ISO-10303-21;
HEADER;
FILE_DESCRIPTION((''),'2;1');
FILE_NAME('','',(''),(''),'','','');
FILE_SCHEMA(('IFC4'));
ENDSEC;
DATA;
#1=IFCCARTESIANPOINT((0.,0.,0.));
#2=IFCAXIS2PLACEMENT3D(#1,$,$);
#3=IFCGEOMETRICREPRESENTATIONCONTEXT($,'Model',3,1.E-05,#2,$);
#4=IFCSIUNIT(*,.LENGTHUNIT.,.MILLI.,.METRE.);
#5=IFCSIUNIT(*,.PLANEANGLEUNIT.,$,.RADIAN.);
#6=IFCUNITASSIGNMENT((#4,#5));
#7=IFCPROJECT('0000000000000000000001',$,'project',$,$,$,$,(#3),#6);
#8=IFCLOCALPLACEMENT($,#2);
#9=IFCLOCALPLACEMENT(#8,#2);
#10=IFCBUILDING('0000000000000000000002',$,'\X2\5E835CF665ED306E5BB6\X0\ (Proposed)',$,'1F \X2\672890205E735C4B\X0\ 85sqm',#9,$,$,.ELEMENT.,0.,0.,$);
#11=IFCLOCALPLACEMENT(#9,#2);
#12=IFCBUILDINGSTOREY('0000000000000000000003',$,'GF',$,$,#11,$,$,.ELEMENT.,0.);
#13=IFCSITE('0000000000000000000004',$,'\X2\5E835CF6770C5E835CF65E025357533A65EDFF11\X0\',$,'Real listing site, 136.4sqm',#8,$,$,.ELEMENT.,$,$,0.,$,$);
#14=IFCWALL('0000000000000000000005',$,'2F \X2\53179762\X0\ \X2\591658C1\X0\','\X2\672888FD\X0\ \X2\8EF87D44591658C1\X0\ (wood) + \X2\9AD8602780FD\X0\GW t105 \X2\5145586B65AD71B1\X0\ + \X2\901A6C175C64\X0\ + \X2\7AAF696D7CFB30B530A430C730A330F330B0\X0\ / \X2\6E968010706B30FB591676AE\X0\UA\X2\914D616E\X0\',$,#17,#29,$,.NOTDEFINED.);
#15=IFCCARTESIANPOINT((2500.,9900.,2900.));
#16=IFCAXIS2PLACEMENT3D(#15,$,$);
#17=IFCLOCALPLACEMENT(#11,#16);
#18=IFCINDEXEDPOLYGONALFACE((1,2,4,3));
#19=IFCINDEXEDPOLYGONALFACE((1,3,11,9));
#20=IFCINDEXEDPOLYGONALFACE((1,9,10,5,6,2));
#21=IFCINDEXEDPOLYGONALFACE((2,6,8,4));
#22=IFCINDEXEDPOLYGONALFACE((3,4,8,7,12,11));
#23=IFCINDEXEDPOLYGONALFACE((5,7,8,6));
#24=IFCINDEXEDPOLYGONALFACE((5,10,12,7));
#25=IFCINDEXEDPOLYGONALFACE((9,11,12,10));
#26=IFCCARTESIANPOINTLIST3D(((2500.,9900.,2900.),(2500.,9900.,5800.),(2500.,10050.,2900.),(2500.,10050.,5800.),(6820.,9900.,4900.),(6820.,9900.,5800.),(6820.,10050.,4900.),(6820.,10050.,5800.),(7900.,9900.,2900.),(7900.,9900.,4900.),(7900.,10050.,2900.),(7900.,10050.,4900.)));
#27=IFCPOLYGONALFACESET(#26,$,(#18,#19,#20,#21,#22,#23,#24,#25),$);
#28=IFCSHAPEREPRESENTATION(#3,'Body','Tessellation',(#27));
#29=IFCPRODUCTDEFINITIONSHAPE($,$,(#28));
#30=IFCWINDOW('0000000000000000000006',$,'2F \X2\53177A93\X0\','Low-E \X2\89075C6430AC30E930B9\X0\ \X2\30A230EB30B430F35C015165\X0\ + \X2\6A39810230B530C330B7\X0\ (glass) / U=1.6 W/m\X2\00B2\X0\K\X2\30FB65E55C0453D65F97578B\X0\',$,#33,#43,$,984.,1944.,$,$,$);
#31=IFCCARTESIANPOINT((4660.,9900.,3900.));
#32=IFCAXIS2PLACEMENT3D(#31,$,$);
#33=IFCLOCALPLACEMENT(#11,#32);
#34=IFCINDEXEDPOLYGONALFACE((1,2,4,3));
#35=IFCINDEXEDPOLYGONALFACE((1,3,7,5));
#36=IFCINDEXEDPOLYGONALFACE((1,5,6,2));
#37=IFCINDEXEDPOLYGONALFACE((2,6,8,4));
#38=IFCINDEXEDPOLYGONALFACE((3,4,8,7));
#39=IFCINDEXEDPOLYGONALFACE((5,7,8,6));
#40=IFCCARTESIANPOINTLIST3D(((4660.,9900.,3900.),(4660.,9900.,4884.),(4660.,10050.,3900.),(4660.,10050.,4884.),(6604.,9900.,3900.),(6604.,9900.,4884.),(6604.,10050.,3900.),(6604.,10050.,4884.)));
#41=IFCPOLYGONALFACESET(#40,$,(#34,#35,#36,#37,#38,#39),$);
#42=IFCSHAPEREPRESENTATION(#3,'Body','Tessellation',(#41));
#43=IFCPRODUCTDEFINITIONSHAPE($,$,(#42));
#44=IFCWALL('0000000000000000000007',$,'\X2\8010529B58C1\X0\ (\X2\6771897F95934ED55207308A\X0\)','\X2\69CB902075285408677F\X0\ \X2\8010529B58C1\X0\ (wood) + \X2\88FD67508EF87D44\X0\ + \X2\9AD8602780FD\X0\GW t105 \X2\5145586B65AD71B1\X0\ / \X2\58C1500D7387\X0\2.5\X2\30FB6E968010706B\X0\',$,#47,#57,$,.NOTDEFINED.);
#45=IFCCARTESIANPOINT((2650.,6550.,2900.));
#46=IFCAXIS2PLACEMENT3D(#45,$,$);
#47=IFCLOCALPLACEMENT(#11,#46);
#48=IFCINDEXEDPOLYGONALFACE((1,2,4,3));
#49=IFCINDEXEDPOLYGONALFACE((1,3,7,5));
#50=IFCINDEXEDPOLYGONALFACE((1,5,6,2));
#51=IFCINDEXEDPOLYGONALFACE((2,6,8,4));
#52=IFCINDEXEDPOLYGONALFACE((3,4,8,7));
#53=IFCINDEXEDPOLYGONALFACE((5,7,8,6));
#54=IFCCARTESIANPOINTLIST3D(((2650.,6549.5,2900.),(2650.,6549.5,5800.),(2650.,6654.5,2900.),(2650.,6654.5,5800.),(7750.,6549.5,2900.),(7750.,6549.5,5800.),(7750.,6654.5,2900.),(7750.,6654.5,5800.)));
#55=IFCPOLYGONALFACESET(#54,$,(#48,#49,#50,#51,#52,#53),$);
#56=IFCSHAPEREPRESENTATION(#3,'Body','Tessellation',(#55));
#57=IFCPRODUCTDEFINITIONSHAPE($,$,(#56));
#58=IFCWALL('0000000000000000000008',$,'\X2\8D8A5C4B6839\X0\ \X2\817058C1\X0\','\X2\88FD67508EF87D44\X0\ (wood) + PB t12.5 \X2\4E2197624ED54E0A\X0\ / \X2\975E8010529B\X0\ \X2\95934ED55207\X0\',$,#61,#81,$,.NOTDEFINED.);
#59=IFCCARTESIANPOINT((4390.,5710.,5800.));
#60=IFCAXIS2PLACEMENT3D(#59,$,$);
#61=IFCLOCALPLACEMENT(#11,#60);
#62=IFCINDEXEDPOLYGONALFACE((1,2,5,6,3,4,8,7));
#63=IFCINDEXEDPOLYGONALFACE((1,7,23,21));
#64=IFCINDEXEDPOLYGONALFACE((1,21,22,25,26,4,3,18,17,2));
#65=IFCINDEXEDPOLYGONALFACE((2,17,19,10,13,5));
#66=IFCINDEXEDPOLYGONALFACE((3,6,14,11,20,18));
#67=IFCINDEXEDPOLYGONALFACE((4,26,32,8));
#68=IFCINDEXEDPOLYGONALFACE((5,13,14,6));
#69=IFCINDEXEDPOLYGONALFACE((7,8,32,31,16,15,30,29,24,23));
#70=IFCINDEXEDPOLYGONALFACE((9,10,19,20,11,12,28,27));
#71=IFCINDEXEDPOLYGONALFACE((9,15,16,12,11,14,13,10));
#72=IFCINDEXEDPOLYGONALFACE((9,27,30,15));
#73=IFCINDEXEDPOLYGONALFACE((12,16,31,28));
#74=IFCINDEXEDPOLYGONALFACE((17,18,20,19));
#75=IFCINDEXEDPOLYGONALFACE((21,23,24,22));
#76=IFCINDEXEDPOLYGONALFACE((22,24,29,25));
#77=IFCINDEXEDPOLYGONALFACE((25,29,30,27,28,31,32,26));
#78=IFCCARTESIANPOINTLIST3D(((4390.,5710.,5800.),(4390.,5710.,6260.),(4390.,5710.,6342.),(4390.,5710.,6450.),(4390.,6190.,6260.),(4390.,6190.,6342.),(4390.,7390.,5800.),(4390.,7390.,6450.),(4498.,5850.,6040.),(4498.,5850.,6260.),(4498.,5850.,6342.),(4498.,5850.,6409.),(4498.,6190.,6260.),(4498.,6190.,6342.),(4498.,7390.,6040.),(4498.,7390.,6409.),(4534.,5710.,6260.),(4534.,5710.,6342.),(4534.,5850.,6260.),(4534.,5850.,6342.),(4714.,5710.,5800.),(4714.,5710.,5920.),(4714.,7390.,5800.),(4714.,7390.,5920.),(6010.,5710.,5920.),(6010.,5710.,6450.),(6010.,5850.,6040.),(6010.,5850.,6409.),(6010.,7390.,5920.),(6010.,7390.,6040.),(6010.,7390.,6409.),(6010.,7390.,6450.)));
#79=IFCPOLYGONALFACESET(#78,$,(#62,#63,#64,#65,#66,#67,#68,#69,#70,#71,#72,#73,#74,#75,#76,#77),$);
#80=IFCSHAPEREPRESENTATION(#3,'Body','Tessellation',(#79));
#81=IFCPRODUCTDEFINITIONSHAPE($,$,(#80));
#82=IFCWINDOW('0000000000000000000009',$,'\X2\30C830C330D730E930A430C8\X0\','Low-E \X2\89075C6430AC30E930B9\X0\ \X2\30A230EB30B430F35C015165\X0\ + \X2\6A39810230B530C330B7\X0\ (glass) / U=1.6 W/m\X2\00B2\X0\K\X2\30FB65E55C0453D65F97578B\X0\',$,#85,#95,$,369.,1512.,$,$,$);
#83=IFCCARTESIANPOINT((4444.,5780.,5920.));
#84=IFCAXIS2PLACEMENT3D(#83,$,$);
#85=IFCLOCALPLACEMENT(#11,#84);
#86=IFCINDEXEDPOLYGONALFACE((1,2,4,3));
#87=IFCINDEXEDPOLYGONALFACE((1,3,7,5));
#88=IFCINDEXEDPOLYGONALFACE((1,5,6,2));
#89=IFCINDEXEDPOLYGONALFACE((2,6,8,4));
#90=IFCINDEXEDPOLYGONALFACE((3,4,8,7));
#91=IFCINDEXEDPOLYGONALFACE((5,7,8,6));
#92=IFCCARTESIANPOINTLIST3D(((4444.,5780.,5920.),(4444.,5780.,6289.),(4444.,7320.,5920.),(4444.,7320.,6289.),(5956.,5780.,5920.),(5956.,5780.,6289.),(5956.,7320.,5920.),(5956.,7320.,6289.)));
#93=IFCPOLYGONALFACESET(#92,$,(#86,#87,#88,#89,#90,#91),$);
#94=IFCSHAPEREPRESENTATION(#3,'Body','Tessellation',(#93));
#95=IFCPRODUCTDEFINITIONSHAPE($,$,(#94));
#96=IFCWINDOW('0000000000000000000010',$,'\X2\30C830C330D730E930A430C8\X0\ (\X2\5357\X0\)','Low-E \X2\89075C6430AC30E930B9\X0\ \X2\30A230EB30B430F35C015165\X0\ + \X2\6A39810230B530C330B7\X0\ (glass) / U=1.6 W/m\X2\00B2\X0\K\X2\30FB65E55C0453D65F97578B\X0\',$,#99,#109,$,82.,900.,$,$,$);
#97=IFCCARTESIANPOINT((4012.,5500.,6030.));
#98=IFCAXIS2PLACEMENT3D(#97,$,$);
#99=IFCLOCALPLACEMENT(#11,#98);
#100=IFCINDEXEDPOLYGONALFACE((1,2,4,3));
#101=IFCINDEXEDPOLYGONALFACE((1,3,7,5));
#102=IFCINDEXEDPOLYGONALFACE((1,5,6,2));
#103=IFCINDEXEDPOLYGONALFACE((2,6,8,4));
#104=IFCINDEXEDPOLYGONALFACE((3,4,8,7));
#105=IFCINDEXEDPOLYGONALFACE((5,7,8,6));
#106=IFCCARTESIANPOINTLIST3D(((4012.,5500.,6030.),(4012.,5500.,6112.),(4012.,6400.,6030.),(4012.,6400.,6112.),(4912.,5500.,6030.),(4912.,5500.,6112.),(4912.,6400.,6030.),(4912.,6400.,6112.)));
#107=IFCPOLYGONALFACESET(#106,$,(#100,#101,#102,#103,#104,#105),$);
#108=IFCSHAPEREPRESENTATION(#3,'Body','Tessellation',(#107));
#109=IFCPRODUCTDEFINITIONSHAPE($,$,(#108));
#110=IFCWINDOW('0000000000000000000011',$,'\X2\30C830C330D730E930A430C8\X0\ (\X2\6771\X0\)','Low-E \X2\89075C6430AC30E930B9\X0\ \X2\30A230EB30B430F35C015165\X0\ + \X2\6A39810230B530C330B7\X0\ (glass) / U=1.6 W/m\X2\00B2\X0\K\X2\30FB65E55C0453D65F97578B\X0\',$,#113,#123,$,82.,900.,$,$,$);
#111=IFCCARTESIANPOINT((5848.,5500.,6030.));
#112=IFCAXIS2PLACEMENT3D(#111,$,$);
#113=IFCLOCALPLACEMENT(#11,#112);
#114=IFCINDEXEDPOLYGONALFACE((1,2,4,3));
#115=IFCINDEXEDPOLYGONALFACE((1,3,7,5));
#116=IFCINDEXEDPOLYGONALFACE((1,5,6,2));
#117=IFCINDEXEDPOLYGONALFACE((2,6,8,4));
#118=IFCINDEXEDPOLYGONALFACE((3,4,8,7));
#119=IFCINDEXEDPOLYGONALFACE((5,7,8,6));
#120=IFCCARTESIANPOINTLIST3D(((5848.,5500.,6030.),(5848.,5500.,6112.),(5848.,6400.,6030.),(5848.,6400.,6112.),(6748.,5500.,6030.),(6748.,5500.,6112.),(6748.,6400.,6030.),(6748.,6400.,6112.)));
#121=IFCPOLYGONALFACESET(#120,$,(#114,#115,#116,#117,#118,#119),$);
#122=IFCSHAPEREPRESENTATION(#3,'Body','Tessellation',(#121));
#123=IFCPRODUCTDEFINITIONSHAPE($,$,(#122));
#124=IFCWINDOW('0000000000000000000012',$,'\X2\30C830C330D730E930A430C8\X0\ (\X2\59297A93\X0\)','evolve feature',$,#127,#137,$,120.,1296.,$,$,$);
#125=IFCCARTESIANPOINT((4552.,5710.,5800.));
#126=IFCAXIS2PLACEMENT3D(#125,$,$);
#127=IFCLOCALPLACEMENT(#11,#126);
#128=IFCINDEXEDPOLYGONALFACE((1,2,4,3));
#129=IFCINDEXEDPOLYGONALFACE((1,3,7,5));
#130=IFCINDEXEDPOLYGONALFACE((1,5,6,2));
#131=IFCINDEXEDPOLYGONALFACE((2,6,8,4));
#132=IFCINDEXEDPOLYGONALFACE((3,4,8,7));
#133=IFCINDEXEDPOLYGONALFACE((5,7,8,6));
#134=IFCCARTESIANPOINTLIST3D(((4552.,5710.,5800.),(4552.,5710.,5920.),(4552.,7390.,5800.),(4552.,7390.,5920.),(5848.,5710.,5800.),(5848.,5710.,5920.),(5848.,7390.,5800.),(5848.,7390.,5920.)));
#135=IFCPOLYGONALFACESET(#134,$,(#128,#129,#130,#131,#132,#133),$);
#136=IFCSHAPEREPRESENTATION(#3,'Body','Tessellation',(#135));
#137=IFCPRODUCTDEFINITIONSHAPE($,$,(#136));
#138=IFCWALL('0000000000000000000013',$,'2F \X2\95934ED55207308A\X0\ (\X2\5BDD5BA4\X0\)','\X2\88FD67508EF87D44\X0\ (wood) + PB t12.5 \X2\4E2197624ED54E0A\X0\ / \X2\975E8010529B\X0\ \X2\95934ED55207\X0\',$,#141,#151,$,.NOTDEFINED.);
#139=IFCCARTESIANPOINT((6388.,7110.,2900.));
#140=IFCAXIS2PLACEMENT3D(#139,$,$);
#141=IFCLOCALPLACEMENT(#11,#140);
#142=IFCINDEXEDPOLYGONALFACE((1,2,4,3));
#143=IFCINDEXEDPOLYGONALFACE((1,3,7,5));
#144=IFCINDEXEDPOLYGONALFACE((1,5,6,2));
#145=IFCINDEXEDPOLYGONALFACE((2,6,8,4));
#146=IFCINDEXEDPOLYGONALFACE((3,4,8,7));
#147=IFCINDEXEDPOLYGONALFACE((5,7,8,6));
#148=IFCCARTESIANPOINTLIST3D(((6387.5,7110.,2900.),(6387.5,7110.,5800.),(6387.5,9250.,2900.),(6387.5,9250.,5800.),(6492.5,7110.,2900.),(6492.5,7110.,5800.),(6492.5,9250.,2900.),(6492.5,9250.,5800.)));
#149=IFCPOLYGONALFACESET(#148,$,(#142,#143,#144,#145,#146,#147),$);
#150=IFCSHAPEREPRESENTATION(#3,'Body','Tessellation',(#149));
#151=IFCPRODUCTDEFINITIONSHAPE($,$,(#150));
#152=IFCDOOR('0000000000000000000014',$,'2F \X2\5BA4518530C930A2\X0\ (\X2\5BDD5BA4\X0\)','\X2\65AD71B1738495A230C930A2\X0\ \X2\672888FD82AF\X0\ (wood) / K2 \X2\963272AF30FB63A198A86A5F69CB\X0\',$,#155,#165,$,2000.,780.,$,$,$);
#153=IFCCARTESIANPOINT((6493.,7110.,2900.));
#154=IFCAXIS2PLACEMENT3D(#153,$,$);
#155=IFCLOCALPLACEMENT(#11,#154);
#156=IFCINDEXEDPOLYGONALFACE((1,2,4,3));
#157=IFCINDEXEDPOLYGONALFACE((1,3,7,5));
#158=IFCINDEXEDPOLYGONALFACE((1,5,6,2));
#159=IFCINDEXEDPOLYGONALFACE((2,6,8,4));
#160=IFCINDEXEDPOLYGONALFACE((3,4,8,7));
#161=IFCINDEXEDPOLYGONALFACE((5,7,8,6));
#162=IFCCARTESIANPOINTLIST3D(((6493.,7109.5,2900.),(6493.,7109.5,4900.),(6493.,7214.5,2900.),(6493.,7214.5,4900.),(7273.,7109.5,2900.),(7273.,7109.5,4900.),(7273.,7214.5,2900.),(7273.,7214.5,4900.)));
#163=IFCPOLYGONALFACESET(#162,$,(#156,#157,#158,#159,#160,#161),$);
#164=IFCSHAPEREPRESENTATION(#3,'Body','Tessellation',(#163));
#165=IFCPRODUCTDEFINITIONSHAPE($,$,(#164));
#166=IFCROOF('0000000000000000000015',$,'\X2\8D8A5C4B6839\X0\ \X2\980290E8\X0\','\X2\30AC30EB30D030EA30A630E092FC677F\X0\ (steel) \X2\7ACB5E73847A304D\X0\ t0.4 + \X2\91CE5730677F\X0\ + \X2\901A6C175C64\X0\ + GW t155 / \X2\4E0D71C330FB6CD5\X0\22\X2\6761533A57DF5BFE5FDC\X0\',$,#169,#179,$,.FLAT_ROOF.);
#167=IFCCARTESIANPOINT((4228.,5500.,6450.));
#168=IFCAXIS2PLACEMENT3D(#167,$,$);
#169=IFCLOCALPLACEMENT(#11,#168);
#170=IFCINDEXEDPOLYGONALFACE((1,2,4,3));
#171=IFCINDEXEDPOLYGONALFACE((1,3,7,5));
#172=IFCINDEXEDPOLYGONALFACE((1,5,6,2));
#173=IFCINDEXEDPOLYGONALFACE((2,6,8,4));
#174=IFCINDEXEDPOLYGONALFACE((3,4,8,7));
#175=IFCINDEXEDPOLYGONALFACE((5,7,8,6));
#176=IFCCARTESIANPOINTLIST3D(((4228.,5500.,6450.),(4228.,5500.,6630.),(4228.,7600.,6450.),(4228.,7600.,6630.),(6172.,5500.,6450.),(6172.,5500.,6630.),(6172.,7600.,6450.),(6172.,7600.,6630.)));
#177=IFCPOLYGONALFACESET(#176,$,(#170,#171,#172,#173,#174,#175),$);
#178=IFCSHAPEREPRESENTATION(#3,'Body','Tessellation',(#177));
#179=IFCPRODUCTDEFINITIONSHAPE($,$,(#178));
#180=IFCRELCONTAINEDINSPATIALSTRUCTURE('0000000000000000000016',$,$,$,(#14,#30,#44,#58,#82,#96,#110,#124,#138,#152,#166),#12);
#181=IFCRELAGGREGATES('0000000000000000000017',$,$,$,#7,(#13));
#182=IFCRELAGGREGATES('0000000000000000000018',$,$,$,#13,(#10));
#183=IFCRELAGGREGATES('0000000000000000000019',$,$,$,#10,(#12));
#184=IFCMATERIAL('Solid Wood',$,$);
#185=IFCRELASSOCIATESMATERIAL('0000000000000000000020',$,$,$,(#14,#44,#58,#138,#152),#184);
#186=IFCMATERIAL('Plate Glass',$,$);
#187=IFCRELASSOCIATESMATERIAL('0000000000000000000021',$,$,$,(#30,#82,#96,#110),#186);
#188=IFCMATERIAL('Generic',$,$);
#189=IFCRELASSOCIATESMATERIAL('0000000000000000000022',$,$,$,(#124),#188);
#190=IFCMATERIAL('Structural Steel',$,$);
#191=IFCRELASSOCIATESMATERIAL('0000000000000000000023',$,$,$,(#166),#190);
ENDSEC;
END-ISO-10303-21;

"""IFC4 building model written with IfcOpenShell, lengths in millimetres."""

from ifc_helpers import new_model, si_unit, frame, frame_2d, origin, place, context, project, spatial, rectangle, extrude, material, element, fill, save


model = new_model("IFC4")

# Units and contexts
model_context = context("Model", 3, precision=1e-05, world=origin())
ifc_project = project(units=[si_unit("LENGTHUNIT", "METRE", prefix="MILLI"), si_unit("PLANEANGLEUNIT", "RADIAN")], contexts=[model_context])

# Site, building, storey
site_placement = place(None, origin())
site = spatial("IfcSite", under=ifc_project, at=site_placement, Name="広島県広島市南区旭１", ObjectType="Real listing site, 136.4sqm", CompositionType="ELEMENT", RefElevation=0.0)
building_placement = place(site_placement, origin())
building = spatial("IfcBuilding", under=site, at=building_placement, Name="広島旭の家 (Proposed)", ObjectType="1F 木造平屋 85sqm", CompositionType="ELEMENT", ElevationOfRefHeight=0.0, ElevationOfTerrain=0.0)
storey_placement = place(building_placement, origin())
storey = spatial("IfcBuildingStorey", under=building, at=storey_placement, Name="GF", CompositionType="ELEMENT", Elevation=0.0)

# Wall, opening, window
ifc_material_1 = material(Name="Solid Wood")
wall_1_placement = place(storey_placement, frame((2500.0, 9900.0, 2900.0)))
wall_1 = element("IfcWall", 1, at=wall_1_placement, inside=storey, material=ifc_material_1, Name="2F 北面 外壁", Description="木製 軸組外壁 (wood) + 高性能GW t105 充填断熱 + 通気層 + 窯業系サイディング / 準耐火・外皮UA配慮", PredefinedType="NOTDEFINED", context=model_context, shape_type="SweptSolid", body=[
    extrude(rectangle(XDim=5400.0, YDim=150.0, at=frame_2d((2700.0, 75.0))), frame((2500.0, 9900.0, 2900.0)), (0.0, 0.0, 1.0), 2900.0),
])
opening_1_placement = place(storey_placement, frame((4660.0, 9900.0, 3900.0)))
opening_1 = element("IfcOpeningElement", 2, at=opening_1_placement, cuts=wall_1, PredefinedType="NOTDEFINED", context=model_context, shape_type="SweptSolid", body=[
    extrude(rectangle(XDim=1944.0, YDim=150.0, at=frame_2d((972.0, 75.0))), frame((4660.0, 9900.0, 3900.0)), (0.0, 0.0, 1.0), 984.0),
])
ifc_material_2 = material(Name="Plate Glass")
window_1_placement = place(storey_placement, frame((4660.0, 9900.0, 3900.0)))
window_1 = element("IfcWindow", 3, at=window_1_placement, inside=storey, material=ifc_material_2, Name="2F 北窓", Description="Low-E 複層ガラス アルゴン封入 + 樹脂サッシ (glass) / U=1.6 W/m²K・日射取得型", OverallHeight=984.0, OverallWidth=1944.0, context=model_context, shape_type="SweptSolid", body=[
    extrude(rectangle(XDim=1944.0, YDim=150.0, at=frame_2d((972.0, 75.0))), frame((4660.0, 9900.0, 3900.0)), (0.0, 0.0, 1.0), 984.0),
])
fill(opening_1, window_1)

# Wall
wall_2_placement = place(storey_placement, frame((2650.0, 6550.0, 2900.0)))
element("IfcWall", 4, at=wall_2_placement, inside=storey, material=ifc_material_1, Name="耐力壁 (東西間仕切り)", Description="構造用合板 耐力壁 (wood) + 製材軸組 + 高性能GW t105 充填断熱 / 壁倍率2.5・準耐火", PredefinedType="NOTDEFINED", context=model_context, shape_type="SweptSolid", body=[
    extrude(rectangle(XDim=5100.0, YDim=105.0, at=frame_2d((2550.0, 52.0))), frame((2650.0, 6550.0, 2900.0)), (0.0, 0.0, 1.0), 2900.0),
])

# Wall, openings, windows
wall_3_placement = place(storey_placement, frame((4390.0, 5710.0, 5800.0)))
wall_3 = element("IfcWall", 5, at=wall_3_placement, inside=storey, material=ifc_material_1, Name="越屋根 腰壁", Description="製材軸組 (wood) + PB t12.5 両面仕上 / 非耐力 間仕切", PredefinedType="NOTDEFINED", context=model_context, shape_type="SweptSolid", body=[
    extrude(rectangle(XDim=1620.0, YDim=1680.0, at=frame_2d((810.0, 840.0))), frame((4390.0, 5710.0, 5800.0)), (0.0, 0.0, 1.0), 650.0),
])
opening_2_placement = place(storey_placement, frame((4444.0, 5780.0, 5920.0)))
opening_2 = element("IfcOpeningElement", 6, at=opening_2_placement, cuts=wall_3, PredefinedType="NOTDEFINED", context=model_context, shape_type="SweptSolid", body=[
    extrude(rectangle(XDim=1512.0, YDim=1540.0, at=frame_2d((756.0, 770.0))), frame((4444.0, 5780.0, 5920.0)), (0.0, 0.0, 1.0), 369.0),
])
opening_3_placement = place(storey_placement, frame((4012.0, 5500.0, 6030.0)))
opening_3 = element("IfcOpeningElement", 7, at=opening_3_placement, cuts=wall_3, PredefinedType="NOTDEFINED", context=model_context, shape_type="SweptSolid", body=[
    extrude(rectangle(XDim=900.0, YDim=900.0, at=frame_2d((450.0, 450.0))), frame((4012.0, 5500.0, 6030.0)), (0.0, 0.0, 1.0), 82.0),
])
opening_4_placement = place(storey_placement, frame((5848.0, 5500.0, 6030.0)))
opening_4 = element("IfcOpeningElement", 8, at=opening_4_placement, cuts=wall_3, PredefinedType="NOTDEFINED", context=model_context, shape_type="SweptSolid", body=[
    extrude(rectangle(XDim=900.0, YDim=900.0, at=frame_2d((450.0, 450.0))), frame((5848.0, 5500.0, 6030.0)), (0.0, 0.0, 1.0), 82.0),
])
opening_5_placement = place(storey_placement, frame((4552.0, 5710.0, 5800.0)))
opening_5 = element("IfcOpeningElement", 9, at=opening_5_placement, cuts=wall_3, PredefinedType="NOTDEFINED", context=model_context, shape_type="SweptSolid", body=[
    extrude(rectangle(XDim=1296.0, YDim=1680.0, at=frame_2d((648.0, 840.0))), frame((4552.0, 5710.0, 5800.0)), (0.0, 0.0, 1.0), 120.0),
])
window_2_placement = place(storey_placement, frame((4444.0, 5780.0, 5920.0)))
window_2 = element("IfcWindow", 10, at=window_2_placement, inside=storey, material=ifc_material_2, Name="トップライト", Description="Low-E 複層ガラス アルゴン封入 + 樹脂サッシ (glass) / U=1.6 W/m²K・日射取得型", OverallHeight=369.0, OverallWidth=1512.0, context=model_context, shape_type="SweptSolid", body=[
    extrude(rectangle(XDim=1512.0, YDim=1540.0, at=frame_2d((756.0, 770.0))), frame((4444.0, 5780.0, 5920.0)), (0.0, 0.0, 1.0), 369.0),
])
fill(opening_2, window_2)
window_3_placement = place(storey_placement, frame((4012.0, 5500.0, 6030.0)))
window_3 = element("IfcWindow", 11, at=window_3_placement, inside=storey, material=ifc_material_2, Name="トップライト (南)", Description="Low-E 複層ガラス アルゴン封入 + 樹脂サッシ (glass) / U=1.6 W/m²K・日射取得型", OverallHeight=82.0, OverallWidth=900.0, context=model_context, shape_type="SweptSolid", body=[
    extrude(rectangle(XDim=900.0, YDim=900.0, at=frame_2d((450.0, 450.0))), frame((4012.0, 5500.0, 6030.0)), (0.0, 0.0, 1.0), 82.0),
])
fill(opening_3, window_3)
window_4_placement = place(storey_placement, frame((5848.0, 5500.0, 6030.0)))
window_4 = element("IfcWindow", 12, at=window_4_placement, inside=storey, material=ifc_material_2, Name="トップライト (東)", Description="Low-E 複層ガラス アルゴン封入 + 樹脂サッシ (glass) / U=1.6 W/m²K・日射取得型", OverallHeight=82.0, OverallWidth=900.0, context=model_context, shape_type="SweptSolid", body=[
    extrude(rectangle(XDim=900.0, YDim=900.0, at=frame_2d((450.0, 450.0))), frame((5848.0, 5500.0, 6030.0)), (0.0, 0.0, 1.0), 82.0),
])
fill(opening_4, window_4)
ifc_material_3 = material(Name="Generic")
window_5_placement = place(storey_placement, frame((4552.0, 5710.0, 5800.0)))
window_5 = element("IfcWindow", 13, at=window_5_placement, inside=storey, material=ifc_material_3, Name="トップライト (天窓)", Description="evolve feature", OverallHeight=120.0, OverallWidth=1296.0, context=model_context, shape_type="SweptSolid", body=[
    extrude(rectangle(XDim=1296.0, YDim=1680.0, at=frame_2d((648.0, 840.0))), frame((4552.0, 5710.0, 5800.0)), (0.0, 0.0, 1.0), 120.0),
])
fill(opening_5, window_5)

# Wall
wall_4_placement = place(storey_placement, frame((6388.0, 7110.0, 2900.0)))
element("IfcWall", 14, at=wall_4_placement, inside=storey, material=ifc_material_1, Name="2F 間仕切り (寝室)", Description="製材軸組 (wood) + PB t12.5 両面仕上 / 非耐力 間仕切", PredefinedType="NOTDEFINED", context=model_context, shape_type="SweptSolid", body=[
    extrude(rectangle(XDim=105.0, YDim=2140.0, at=frame_2d((52.0, 1070.0))), frame((6388.0, 7110.0, 2900.0)), (0.0, 0.0, 1.0), 2900.0),
])

# Door
door_placement = place(storey_placement, frame((6493.0, 7110.0, 2900.0)))
element("IfcDoor", 15, at=door_placement, inside=storey, material=ifc_material_1, Name="2F 室内ドア (寝室)", Description="断熱玄関ドア 木製芯 (wood) / K2 防犯・採風機構", OverallHeight=2000.0, OverallWidth=780.0, context=model_context, shape_type="SweptSolid", body=[
    extrude(rectangle(XDim=780.0, YDim=105.0, at=frame_2d((390.0, 52.0))), frame((6493.0, 7110.0, 2900.0)), (0.0, 0.0, 1.0), 2000.0),
])

# Roof
ifc_material_4 = material(Name="Structural Steel")
roof_placement = place(storey_placement, frame((4228.0, 5500.0, 6450.0)))
element("IfcRoof", 16, at=roof_placement, inside=storey, material=ifc_material_4, Name="越屋根 頂部", Description="ガルバリウム鋼板 (steel) 立平葺き t0.4 + 野地板 + 通気層 + GW t155 / 不燃・法22条区域対応", PredefinedType="FLAT_ROOF", context=model_context, shape_type="SweptSolid", body=[
    extrude(rectangle(XDim=1944.0, YDim=2100.0, at=frame_2d((972.0, 1050.0))), frame((4228.0, 5500.0, 6450.0)), (0.0, 0.0, 1.0), 180.0),
])

save(model, "model.ifc")
